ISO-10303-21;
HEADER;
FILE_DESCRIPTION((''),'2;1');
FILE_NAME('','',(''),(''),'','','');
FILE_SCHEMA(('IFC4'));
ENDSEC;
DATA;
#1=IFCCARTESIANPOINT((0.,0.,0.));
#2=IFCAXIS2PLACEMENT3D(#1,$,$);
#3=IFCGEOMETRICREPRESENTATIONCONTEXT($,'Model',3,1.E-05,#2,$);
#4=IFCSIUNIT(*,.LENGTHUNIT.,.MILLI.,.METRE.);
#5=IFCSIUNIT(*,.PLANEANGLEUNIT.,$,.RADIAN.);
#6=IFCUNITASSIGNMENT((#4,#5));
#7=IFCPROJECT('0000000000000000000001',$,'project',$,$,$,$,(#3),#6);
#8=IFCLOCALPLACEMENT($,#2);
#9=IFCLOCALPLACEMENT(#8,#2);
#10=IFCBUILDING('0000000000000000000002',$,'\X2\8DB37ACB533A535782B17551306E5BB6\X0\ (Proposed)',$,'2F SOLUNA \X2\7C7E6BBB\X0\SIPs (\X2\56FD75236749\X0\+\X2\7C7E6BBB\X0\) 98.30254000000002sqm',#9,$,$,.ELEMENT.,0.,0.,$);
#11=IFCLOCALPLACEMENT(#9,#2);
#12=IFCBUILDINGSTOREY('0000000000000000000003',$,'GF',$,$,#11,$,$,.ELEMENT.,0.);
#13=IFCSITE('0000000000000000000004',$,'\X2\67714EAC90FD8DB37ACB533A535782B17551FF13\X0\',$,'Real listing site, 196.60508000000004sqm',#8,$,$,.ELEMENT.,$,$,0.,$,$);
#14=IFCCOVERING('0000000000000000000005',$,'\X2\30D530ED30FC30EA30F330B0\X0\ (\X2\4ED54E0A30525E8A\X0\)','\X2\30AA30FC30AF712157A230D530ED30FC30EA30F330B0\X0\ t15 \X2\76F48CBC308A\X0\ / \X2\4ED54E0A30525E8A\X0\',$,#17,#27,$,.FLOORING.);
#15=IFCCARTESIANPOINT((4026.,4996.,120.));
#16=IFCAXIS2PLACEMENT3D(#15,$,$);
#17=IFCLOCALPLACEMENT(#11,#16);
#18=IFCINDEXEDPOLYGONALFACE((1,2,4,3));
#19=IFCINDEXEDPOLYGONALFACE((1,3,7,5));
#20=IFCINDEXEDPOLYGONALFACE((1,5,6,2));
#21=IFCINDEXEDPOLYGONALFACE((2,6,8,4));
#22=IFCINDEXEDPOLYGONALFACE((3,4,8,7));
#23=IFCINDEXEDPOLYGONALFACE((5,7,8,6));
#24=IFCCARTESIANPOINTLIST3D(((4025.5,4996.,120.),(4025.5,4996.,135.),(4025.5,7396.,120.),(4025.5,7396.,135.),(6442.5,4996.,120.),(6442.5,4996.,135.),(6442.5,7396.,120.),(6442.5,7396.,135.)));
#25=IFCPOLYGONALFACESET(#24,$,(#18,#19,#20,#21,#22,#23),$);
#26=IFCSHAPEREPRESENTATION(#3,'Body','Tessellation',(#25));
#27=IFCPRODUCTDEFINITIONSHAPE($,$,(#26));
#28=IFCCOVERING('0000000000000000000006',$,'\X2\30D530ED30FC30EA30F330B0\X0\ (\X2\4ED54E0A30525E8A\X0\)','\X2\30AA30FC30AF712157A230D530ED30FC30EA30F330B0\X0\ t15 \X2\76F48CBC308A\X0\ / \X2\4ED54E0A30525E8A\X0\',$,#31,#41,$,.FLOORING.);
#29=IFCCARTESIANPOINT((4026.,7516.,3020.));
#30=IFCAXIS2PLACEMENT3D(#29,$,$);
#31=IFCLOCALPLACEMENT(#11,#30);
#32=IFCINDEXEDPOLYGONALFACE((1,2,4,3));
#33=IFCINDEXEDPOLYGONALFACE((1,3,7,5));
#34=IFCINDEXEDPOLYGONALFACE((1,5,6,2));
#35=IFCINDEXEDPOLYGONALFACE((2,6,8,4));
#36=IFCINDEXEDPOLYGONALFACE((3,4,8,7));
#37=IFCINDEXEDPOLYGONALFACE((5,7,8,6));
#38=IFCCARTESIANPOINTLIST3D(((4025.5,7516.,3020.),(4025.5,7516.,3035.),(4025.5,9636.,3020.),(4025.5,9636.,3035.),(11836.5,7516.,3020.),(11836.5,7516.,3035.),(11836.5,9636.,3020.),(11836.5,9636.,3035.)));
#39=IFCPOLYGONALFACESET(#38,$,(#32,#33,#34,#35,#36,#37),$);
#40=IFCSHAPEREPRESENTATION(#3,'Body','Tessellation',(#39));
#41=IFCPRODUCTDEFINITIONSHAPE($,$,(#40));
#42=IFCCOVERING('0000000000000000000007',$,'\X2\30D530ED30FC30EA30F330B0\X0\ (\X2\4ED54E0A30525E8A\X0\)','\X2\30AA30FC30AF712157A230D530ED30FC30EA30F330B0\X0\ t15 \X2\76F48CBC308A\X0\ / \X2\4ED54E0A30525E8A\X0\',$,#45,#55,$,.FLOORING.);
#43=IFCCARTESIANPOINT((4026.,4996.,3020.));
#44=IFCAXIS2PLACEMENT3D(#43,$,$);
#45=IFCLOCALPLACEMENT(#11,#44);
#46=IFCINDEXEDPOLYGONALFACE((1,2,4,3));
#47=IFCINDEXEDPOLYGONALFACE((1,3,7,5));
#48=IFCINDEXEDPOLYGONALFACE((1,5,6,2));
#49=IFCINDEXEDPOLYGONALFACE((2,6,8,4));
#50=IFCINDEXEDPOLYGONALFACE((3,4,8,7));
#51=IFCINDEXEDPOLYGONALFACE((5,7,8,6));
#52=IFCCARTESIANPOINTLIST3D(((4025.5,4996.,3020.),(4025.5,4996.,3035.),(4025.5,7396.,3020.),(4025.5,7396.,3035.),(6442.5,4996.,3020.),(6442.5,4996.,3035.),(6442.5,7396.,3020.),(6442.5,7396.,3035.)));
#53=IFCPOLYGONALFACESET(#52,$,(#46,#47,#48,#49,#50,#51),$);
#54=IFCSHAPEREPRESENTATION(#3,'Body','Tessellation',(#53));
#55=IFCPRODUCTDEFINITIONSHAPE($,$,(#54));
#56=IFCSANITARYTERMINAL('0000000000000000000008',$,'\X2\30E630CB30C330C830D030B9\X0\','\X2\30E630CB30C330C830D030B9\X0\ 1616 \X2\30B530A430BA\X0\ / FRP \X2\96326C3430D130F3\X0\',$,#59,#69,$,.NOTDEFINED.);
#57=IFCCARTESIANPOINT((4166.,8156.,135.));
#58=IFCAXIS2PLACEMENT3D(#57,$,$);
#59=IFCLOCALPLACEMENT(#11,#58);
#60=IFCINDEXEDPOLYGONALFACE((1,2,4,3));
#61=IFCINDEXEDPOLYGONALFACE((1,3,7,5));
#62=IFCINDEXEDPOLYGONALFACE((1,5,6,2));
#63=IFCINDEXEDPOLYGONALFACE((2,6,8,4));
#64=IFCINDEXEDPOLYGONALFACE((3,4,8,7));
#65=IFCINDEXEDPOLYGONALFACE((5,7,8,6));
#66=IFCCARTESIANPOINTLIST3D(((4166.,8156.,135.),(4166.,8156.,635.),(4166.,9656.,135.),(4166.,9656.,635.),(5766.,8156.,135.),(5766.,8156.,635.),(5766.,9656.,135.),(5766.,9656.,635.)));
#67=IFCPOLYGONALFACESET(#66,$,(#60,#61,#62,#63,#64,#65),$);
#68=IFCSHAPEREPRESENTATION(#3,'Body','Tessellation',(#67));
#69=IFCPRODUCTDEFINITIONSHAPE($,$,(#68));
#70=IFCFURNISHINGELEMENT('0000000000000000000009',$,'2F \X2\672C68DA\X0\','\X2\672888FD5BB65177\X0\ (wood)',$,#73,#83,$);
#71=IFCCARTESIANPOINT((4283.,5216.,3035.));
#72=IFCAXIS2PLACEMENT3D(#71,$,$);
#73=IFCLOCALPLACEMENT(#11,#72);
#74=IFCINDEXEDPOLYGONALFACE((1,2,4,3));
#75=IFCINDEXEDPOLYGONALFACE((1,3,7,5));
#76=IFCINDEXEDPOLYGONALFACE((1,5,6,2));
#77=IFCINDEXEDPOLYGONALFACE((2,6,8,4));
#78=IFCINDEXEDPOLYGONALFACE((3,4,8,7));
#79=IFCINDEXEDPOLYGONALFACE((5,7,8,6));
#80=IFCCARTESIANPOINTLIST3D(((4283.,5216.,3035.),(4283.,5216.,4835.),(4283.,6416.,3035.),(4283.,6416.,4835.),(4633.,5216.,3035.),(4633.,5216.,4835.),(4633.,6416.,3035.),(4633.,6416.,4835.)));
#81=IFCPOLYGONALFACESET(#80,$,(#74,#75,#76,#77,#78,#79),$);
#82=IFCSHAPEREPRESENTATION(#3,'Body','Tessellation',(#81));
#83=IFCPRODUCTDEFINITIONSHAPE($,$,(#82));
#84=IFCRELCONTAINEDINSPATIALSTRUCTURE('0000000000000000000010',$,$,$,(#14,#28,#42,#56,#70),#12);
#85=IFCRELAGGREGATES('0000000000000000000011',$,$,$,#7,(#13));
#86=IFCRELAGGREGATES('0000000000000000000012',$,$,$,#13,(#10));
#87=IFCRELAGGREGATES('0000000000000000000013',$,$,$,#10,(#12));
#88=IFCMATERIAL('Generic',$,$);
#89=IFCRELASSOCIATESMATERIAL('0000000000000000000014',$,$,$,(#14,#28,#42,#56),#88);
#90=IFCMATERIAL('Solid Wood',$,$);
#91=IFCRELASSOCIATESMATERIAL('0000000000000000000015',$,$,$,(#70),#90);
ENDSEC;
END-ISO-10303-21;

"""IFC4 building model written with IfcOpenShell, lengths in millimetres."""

from ifc_helpers import new_model, si_unit, frame, frame_2d, origin, place, context, project, spatial, rectangle, extrude, material, element, save


model = new_model("IFC4")

# Units and contexts
model_context = context("Model", 3, precision=1e-05, world=origin())
ifc_project = project(units=[si_unit("LENGTHUNIT", "METRE", prefix="MILLI"), si_unit("PLANEANGLEUNIT", "RADIAN")], contexts=[model_context])

# Site, building, storey
site_placement = place(None, origin())
site = spatial("IfcSite", under=ifc_project, at=site_placement, Name="東京都足立区南花畑３", ObjectType="Real listing site, 196.60508000000004sqm", CompositionType="ELEMENT", RefElevation=0.0)
building_placement = place(site_placement, origin())
building = spatial("IfcBuilding", under=site, at=building_placement, Name="足立区南花畑の家 (Proposed)", ObjectType="2F SOLUNA 籾殻SIPs (国産杉+籾殻) 98.30254000000002sqm", CompositionType="ELEMENT", ElevationOfRefHeight=0.0, ElevationOfTerrain=0.0)
storey_placement = place(building_placement, origin())
storey = spatial("IfcBuildingStorey", under=building, at=storey_placement, Name="GF", CompositionType="ELEMENT", Elevation=0.0)

# Shared definitions
ifc_material_1 = material(Name="Solid Wood")

# Coverings
ifc_material_2 = material(Name="Generic")
covering_1_placement = place(storey_placement, frame((4026.0, 4996.0, 120.0)))
element("IfcCovering", 1, at=covering_1_placement, inside=storey, material=ifc_material_2, Name="フローリング (仕上げ床)", Description="オーク無垢フローリング t15 直貼り / 仕上げ床", PredefinedType="FLOORING", context=model_context, shape_type="SweptSolid", body=[
    extrude(rectangle(XDim=2417.0, YDim=2400.0, at=frame_2d((1208.0, 1200.0))), frame((4026.0, 4996.0, 120.0)), (0.0, 0.0, 1.0), 15.0),
])
covering_2_placement = place(storey_placement, frame((4026.0, 7516.0, 3020.0)))
element("IfcCovering", 2, at=covering_2_placement, inside=storey, material=ifc_material_2, Name="フローリング (仕上げ床)", Description="オーク無垢フローリング t15 直貼り / 仕上げ床", PredefinedType="FLOORING", context=model_context, shape_type="SweptSolid", body=[
    extrude(rectangle(XDim=7811.0, YDim=2120.0, at=frame_2d((3905.0, 1060.0))), frame((4026.0, 7516.0, 3020.0)), (0.0, 0.0, 1.0), 15.0),
])
covering_3_placement = place(storey_placement, frame((4026.0, 4996.0, 3020.0)))
element("IfcCovering", 3, at=covering_3_placement, inside=storey, material=ifc_material_2, Name="フローリング (仕上げ床)", Description="オーク無垢フローリング t15 直貼り / 仕上げ床", PredefinedType="FLOORING", context=model_context, shape_type="SweptSolid", body=[
    extrude(rectangle(XDim=2417.0, YDim=2400.0, at=frame_2d((1208.0, 1200.0))), frame((4026.0, 4996.0, 3020.0)), (0.0, 0.0, 1.0), 15.0),
])

# Sanitary terminal
sanitary_terminal_placement = place(storey_placement, frame((4166.0, 8156.0, 135.0)))
element("IfcSanitaryTerminal", 4, at=sanitary_terminal_placement, inside=storey, material=ifc_material_2, Name="ユニットバス", Description="ユニットバス 1616 サイズ / FRP 防水パン", PredefinedType="NOTDEFINED", context=model_context, shape_type="SweptSolid", body=[
    extrude(rectangle(XDim=1600.0, YDim=1500.0, at=frame_2d((800.0, 750.0))), frame((4166.0, 8156.0, 135.0)), (0.0, 0.0, 1.0), 500.0),
])

# Furnishing element
furnishing_placement = place(storey_placement, frame((4283.0, 5216.0, 3035.0)))
element("IfcFurnishingElement", 5, at=furnishing_placement, inside=storey, material=ifc_material_1, Name="2F 本棚", Description="木製家具 (wood)", context=model_context, shape_type="SweptSolid", body=[
    extrude(rectangle(XDim=350.0, YDim=1200.0, at=frame_2d((175.0, 600.0))), frame((4283.0, 5216.0, 3035.0)), (0.0, 0.0, 1.0), 1800.0),
])

save(model, "model.ifc")
